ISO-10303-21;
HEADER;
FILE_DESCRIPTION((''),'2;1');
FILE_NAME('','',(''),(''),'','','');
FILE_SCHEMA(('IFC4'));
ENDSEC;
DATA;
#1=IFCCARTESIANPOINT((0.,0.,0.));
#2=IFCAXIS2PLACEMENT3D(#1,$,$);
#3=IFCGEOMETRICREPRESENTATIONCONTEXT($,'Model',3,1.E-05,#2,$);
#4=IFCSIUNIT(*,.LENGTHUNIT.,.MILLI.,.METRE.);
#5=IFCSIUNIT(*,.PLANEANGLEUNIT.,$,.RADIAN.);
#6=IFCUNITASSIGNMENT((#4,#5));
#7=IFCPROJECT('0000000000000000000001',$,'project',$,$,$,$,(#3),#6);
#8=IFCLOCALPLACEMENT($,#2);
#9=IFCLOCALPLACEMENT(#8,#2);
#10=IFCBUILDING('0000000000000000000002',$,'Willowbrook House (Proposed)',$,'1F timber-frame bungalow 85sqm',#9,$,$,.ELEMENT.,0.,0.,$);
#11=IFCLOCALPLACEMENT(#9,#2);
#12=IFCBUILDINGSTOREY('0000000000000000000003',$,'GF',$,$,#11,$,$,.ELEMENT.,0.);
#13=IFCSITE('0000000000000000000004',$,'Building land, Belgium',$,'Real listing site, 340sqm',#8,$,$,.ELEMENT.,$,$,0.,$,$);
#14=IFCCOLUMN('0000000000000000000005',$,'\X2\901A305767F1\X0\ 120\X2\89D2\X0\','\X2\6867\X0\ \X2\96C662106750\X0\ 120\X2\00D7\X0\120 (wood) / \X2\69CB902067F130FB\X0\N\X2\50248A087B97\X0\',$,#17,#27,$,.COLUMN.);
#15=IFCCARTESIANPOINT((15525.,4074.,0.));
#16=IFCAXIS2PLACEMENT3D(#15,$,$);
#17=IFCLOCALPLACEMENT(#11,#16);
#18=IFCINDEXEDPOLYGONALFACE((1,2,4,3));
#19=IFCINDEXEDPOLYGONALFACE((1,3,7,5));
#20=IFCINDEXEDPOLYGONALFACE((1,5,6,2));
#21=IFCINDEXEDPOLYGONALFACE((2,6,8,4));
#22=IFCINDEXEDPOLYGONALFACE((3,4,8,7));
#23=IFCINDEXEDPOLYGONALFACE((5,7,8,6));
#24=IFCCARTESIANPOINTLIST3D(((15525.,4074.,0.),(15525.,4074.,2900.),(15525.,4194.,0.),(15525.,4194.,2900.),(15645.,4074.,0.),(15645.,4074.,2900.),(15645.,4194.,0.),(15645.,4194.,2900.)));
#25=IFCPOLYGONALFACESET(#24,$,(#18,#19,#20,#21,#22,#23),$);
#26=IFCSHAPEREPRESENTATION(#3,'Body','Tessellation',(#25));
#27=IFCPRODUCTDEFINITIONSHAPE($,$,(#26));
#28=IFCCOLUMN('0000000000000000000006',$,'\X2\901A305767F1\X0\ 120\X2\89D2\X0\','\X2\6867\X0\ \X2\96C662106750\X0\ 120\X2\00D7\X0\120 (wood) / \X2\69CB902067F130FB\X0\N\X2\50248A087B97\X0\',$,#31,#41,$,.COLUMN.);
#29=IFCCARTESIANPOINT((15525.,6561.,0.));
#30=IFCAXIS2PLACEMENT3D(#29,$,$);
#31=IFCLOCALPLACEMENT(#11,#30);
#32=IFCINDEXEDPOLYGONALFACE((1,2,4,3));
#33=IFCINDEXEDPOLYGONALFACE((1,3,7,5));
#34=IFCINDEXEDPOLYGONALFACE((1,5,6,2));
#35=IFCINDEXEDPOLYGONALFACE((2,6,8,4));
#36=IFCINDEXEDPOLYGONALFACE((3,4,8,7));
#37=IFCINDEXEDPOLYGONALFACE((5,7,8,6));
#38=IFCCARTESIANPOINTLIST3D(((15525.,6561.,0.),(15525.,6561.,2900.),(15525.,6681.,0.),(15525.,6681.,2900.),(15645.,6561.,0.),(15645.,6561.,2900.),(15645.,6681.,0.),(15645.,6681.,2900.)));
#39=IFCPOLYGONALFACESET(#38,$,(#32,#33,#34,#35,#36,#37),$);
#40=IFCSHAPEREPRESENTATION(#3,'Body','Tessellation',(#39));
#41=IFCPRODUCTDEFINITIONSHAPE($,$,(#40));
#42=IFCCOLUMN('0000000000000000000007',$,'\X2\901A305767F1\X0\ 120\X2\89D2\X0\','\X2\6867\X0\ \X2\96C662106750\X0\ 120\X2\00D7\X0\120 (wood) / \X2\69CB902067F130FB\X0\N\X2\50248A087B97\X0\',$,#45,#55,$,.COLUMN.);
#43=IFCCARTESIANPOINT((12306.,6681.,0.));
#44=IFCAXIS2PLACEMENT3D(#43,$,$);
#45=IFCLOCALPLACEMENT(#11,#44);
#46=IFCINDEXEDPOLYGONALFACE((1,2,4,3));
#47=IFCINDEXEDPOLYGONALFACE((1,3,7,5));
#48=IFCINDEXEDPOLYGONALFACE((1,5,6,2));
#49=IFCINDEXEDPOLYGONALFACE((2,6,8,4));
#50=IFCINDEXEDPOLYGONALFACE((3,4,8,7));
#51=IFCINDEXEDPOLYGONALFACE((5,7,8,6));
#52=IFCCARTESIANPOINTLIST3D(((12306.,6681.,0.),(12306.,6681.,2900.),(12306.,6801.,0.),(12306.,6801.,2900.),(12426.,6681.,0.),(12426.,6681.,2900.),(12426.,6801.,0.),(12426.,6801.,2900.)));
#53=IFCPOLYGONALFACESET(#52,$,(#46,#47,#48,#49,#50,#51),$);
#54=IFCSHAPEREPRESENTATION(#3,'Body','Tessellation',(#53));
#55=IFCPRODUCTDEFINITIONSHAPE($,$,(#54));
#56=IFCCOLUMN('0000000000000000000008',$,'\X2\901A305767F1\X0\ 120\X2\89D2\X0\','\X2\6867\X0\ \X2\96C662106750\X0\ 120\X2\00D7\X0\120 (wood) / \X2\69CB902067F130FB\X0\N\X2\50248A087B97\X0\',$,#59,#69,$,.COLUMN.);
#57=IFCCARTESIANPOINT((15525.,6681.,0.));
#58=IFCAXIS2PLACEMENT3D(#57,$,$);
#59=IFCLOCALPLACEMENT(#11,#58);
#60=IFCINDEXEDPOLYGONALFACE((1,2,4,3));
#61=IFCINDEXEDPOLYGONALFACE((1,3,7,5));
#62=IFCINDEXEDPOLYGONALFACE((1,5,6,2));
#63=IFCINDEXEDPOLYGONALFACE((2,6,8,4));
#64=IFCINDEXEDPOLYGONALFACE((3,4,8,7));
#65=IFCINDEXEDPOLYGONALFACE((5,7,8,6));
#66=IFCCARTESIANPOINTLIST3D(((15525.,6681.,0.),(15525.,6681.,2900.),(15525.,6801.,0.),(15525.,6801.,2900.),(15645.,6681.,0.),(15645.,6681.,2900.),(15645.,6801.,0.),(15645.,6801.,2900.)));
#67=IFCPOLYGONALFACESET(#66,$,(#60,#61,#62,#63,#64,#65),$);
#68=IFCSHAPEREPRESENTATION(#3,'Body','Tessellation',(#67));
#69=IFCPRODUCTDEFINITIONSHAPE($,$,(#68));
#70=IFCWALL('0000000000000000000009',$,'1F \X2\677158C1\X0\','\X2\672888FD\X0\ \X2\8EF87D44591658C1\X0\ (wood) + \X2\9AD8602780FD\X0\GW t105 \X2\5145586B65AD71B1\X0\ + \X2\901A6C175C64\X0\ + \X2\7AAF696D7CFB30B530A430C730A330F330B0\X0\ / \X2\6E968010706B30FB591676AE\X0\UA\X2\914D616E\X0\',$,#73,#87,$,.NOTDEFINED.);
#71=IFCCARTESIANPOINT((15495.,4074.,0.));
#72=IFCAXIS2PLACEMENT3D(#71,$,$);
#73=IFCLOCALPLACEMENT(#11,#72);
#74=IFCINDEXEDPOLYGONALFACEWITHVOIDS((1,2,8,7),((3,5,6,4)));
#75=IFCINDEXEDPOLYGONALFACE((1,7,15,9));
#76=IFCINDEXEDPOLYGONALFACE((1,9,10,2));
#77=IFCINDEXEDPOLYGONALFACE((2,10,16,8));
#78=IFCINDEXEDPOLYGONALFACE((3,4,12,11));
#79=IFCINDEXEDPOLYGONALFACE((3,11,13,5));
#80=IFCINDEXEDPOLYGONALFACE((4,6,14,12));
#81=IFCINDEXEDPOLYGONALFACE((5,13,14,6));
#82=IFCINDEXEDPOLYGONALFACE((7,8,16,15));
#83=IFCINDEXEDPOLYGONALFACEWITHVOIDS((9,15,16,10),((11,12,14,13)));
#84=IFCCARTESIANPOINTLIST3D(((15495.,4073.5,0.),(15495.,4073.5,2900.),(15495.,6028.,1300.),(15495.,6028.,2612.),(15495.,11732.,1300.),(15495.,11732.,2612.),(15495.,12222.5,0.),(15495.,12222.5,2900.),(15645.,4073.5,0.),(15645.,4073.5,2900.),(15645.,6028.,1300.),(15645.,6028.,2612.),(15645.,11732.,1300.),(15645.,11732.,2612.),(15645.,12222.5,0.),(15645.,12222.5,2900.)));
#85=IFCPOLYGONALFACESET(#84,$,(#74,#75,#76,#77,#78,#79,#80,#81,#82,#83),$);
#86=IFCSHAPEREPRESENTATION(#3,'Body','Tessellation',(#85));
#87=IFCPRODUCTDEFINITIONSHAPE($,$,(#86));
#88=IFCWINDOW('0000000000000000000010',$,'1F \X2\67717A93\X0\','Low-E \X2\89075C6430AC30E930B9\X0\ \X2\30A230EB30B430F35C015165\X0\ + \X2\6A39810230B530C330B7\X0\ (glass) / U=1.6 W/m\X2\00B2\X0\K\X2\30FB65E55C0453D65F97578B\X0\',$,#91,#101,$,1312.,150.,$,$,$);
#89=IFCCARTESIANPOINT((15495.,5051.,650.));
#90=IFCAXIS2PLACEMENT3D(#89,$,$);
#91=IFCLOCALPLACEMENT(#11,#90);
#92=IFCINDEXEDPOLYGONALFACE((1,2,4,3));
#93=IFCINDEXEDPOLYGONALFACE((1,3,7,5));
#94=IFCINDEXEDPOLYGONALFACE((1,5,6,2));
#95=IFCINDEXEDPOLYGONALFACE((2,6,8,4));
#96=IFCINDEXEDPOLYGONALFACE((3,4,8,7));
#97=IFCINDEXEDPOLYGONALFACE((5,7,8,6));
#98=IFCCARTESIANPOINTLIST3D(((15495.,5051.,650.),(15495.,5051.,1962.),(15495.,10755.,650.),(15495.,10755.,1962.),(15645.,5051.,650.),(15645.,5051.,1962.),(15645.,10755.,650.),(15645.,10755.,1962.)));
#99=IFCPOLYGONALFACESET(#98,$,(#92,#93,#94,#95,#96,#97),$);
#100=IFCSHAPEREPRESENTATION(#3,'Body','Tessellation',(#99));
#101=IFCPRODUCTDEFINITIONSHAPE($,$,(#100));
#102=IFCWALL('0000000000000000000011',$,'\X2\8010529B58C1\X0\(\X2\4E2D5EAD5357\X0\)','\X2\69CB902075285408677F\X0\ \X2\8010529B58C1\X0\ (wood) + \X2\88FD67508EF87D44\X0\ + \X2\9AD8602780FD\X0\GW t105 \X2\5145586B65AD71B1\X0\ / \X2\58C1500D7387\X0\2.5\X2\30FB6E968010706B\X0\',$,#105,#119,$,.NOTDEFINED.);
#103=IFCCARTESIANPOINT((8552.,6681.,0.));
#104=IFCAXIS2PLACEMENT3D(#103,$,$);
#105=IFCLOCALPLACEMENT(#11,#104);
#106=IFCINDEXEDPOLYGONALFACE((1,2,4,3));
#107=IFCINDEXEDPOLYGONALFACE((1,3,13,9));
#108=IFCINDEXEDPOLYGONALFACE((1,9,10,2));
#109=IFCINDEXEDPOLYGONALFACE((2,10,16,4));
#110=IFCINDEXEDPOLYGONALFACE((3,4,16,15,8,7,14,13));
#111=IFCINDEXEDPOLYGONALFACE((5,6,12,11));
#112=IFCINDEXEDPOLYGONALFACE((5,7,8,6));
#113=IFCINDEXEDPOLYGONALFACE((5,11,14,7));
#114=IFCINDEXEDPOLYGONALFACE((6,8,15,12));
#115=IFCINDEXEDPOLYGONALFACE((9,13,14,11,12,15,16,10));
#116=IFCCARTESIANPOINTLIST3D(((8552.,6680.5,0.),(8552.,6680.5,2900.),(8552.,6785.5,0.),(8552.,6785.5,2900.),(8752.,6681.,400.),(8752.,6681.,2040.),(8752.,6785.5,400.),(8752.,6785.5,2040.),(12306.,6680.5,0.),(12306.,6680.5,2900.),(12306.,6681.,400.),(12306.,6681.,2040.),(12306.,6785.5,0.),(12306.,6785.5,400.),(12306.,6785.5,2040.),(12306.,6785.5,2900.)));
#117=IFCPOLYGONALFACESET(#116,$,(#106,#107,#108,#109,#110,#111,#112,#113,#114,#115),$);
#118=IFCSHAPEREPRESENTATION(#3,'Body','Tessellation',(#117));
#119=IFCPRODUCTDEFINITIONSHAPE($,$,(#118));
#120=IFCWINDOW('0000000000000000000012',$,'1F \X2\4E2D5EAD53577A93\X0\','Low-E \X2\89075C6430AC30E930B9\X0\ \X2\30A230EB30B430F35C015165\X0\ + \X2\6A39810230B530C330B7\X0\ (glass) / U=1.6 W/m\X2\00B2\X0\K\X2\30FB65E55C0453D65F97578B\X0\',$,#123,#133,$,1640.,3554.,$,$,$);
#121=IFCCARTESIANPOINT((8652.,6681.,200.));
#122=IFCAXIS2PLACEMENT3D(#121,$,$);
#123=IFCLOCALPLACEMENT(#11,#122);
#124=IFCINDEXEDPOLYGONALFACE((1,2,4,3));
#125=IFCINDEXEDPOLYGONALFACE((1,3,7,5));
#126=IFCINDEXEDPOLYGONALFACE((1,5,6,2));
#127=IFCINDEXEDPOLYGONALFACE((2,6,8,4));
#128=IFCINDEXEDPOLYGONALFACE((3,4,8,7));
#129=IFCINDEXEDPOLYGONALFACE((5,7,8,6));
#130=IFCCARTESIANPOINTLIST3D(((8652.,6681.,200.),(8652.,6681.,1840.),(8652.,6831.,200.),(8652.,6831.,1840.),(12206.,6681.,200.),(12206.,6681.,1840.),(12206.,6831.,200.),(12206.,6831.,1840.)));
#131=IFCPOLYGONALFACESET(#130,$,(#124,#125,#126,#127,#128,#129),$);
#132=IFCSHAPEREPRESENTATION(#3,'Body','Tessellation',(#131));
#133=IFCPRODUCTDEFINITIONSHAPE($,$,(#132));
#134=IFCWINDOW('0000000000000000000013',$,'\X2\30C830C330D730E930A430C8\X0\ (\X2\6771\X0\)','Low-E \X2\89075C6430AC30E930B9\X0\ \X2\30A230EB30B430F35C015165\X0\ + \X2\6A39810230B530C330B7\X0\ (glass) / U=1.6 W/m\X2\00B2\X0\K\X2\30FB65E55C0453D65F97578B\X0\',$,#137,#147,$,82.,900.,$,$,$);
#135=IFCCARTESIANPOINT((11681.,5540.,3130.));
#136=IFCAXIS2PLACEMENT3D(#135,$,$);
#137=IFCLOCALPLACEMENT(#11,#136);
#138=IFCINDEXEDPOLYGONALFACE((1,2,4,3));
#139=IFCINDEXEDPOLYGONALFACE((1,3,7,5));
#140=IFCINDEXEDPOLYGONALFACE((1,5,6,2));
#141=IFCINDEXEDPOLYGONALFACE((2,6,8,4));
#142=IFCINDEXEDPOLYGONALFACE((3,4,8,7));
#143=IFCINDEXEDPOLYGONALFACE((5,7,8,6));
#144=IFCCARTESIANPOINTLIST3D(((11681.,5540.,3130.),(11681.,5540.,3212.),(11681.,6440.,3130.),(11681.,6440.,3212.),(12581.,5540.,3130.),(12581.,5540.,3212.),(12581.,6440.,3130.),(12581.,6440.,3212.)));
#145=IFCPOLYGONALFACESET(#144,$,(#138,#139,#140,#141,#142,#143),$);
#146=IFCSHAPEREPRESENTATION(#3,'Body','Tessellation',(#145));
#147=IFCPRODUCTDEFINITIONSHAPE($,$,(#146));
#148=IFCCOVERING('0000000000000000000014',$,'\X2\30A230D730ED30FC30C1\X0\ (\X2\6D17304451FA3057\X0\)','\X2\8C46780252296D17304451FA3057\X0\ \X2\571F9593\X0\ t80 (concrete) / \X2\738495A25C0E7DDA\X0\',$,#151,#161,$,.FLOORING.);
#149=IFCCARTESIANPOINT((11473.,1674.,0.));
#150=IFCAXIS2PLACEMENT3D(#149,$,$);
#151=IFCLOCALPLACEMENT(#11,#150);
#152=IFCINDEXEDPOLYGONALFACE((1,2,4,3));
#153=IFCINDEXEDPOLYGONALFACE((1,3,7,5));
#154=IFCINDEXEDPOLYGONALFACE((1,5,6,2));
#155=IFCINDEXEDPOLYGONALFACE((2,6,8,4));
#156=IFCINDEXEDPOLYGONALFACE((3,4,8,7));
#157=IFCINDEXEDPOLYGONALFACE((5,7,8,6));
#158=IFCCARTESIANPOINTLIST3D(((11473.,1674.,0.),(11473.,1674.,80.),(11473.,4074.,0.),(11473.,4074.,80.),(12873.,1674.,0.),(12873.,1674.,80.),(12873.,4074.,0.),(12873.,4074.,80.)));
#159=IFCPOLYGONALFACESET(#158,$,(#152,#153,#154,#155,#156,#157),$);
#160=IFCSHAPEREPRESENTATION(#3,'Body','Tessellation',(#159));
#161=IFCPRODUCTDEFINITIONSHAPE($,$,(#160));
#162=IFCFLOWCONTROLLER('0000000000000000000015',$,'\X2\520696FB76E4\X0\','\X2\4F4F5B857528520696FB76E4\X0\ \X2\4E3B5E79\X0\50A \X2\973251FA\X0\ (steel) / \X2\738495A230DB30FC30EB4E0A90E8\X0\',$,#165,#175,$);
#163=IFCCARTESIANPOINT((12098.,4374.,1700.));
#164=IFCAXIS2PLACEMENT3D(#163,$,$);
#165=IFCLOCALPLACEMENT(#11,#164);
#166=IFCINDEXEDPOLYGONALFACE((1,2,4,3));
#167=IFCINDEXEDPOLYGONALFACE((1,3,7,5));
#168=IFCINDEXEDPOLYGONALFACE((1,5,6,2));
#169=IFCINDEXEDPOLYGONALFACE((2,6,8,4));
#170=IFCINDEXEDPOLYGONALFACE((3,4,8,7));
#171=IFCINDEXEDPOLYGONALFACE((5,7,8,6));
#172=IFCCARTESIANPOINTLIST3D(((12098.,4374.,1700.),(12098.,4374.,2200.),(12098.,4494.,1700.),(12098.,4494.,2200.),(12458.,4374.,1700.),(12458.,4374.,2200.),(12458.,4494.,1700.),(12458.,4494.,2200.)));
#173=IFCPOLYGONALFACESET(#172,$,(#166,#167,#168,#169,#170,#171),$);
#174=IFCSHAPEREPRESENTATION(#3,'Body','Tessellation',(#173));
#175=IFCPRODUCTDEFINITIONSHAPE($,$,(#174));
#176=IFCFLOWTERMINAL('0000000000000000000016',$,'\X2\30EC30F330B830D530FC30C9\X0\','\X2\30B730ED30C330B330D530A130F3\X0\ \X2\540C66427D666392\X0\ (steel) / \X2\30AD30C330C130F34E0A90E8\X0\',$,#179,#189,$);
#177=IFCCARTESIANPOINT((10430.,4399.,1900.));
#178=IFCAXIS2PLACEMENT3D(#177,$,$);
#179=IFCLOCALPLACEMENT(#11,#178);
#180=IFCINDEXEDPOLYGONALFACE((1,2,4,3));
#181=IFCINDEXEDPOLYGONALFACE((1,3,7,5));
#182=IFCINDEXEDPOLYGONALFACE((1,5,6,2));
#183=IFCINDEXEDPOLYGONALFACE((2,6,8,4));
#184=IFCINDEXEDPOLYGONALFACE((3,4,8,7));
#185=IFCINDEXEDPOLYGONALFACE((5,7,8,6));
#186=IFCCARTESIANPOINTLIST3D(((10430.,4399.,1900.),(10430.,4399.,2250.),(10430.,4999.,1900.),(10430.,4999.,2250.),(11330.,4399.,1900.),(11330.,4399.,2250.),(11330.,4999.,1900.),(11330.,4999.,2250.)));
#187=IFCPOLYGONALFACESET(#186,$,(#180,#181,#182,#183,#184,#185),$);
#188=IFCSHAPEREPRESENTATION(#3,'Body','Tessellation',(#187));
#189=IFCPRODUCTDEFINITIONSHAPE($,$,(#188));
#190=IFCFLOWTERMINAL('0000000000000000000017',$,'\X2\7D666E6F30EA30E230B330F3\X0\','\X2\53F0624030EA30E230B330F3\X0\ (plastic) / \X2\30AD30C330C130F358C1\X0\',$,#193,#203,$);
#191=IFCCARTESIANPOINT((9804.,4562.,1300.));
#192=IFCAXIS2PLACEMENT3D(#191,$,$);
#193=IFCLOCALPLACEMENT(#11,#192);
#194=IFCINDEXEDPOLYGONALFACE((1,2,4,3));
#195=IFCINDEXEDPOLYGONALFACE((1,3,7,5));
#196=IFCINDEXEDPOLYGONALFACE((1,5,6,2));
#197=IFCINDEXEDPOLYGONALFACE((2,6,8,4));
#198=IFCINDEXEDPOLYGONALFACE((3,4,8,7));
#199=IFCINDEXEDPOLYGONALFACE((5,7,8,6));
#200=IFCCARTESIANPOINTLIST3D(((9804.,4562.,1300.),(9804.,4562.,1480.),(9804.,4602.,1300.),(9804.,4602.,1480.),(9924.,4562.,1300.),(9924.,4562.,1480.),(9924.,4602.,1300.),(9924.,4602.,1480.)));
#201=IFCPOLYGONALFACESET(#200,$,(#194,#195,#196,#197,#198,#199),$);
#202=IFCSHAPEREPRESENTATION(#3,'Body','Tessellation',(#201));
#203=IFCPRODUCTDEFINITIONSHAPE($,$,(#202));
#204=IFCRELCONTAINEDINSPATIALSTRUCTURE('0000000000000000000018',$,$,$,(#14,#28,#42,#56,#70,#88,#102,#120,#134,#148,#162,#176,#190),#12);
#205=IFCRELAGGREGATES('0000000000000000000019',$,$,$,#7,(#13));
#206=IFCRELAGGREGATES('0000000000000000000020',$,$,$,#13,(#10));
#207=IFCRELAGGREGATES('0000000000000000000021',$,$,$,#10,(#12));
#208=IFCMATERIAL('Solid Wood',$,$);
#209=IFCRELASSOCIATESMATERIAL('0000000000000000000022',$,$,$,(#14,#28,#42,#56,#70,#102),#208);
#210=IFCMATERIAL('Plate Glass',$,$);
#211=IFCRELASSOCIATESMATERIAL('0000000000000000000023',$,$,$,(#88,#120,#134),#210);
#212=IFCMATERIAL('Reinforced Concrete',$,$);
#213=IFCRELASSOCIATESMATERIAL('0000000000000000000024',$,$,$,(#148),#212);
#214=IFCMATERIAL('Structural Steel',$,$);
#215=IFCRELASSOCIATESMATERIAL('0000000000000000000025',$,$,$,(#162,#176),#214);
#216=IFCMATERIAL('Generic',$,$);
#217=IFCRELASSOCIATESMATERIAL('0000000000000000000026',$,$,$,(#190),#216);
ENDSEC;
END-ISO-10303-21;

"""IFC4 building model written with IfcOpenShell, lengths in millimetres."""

from ifc_helpers import new_model, si_unit, frame, frame_2d, origin, place, context, project, spatial, rectangle, extrude, material, element, fill, save


model = new_model("IFC4")

# Units and contexts
model_context = context("Model", 3, precision=1e-05, world=origin())
ifc_project = project(units=[si_unit("LENGTHUNIT", "METRE", prefix="MILLI"), si_unit("PLANEANGLEUNIT", "RADIAN")], contexts=[model_context])

# Site, building, storey
site_placement = place(None, origin())
site = spatial("IfcSite", under=ifc_project, at=site_placement, Name="Building land, Belgium", ObjectType="Real listing site, 340sqm", CompositionType="ELEMENT", RefElevation=0.0)
building_placement = place(site_placement, origin())
building = spatial("IfcBuilding", under=site, at=building_placement, Name="Willowbrook House (Proposed)", ObjectType="1F timber-frame bungalow 85sqm", CompositionType="ELEMENT", ElevationOfRefHeight=0.0, ElevationOfTerrain=0.0)
storey_placement = place(building_placement, origin())
storey = spatial("IfcBuildingStorey", under=building, at=storey_placement, Name="GF", CompositionType="ELEMENT", Elevation=0.0)

# Columns
ifc_material_1 = material(Name="Solid Wood")
column_1_placement = place(storey_placement, frame((15525.0, 4074.0, 0.0)))
element("IfcColumn", 1, at=column_1_placement, inside=storey, material=ifc_material_1, Name="通し柱 120角", Description="桧 集成材 120×120 (wood) / 構造柱・N値計算", PredefinedType="COLUMN", context=model_context, shape_type="SweptSolid", body=[
    extrude(rectangle(XDim=120.0, YDim=120.0, at=frame_2d((60.0, 60.0))), frame((15525.0, 4074.0, 0.0)), (0.0, 0.0, 1.0), 2900.0),
])
column_2_placement = place(storey_placement, frame((15525.0, 6561.0, 0.0)))
element("IfcColumn", 2, at=column_2_placement, inside=storey, material=ifc_material_1, Name="通し柱 120角", Description="桧 集成材 120×120 (wood) / 構造柱・N値計算", PredefinedType="COLUMN", context=model_context, shape_type="SweptSolid", body=[
    extrude(rectangle(XDim=120.0, YDim=120.0, at=frame_2d((60.0, 60.0))), frame((15525.0, 6561.0, 0.0)), (0.0, 0.0, 1.0), 2900.0),
])
column_3_placement = place(storey_placement, frame((12306.0, 6681.0, 0.0)))
element("IfcColumn", 3, at=column_3_placement, inside=storey, material=ifc_material_1, Name="通し柱 120角", Description="桧 集成材 120×120 (wood) / 構造柱・N値計算", PredefinedType="COLUMN", context=model_context, shape_type="SweptSolid", body=[
    extrude(rectangle(XDim=120.0, YDim=120.0, at=frame_2d((60.0, 60.0))), frame((12306.0, 6681.0, 0.0)), (0.0, 0.0, 1.0), 2900.0),
])
column_4_placement = place(storey_placement, frame((15525.0, 6681.0, 0.0)))
element("IfcColumn", 4, at=column_4_placement, inside=storey, material=ifc_material_1, Name="通し柱 120角", Description="桧 集成材 120×120 (wood) / 構造柱・N値計算", PredefinedType="COLUMN", context=model_context, shape_type="SweptSolid", body=[
    extrude(rectangle(XDim=120.0, YDim=120.0, at=frame_2d((60.0, 60.0))), frame((15525.0, 6681.0, 0.0)), (0.0, 0.0, 1.0), 2900.0),
])

# Walls, openings, windows
wall_1_placement = place(storey_placement, frame((15495.0, 4074.0, 0.0)))
wall_1 = element("IfcWall", 5, at=wall_1_placement, inside=storey, material=ifc_material_1, Name="1F 東壁", Description="木製 軸組外壁 (wood) + 高性能GW t105 充填断熱 + 通気層 + 窯業系サイディング / 準耐火・外皮UA配慮", PredefinedType="NOTDEFINED", context=model_context, shape_type="SweptSolid", body=[
    extrude(rectangle(XDim=150.0, YDim=8149.0, at=frame_2d((75.0, 4074.0))), frame((15495.0, 4074.0, 0.0)), (0.0, 0.0, 1.0), 2900.0),
])
opening_1_placement = place(storey_placement, frame((15495.0, 5051.0, 650.0)))
opening_1 = element("IfcOpeningElement", 6, at=opening_1_placement, cuts=wall_1, PredefinedType="NOTDEFINED", context=model_context, shape_type="SweptSolid", body=[
    extrude(rectangle(XDim=150.0, YDim=5704.0, at=frame_2d((75.0, 2852.0))), frame((15495.0, 5051.0, 650.0)), (0.0, 0.0, 1.0), 1312.0),
])
ifc_material_2 = material(Name="Plate Glass")
window_1_placement = place(storey_placement, frame((15495.0, 5051.0, 650.0)))
window_1 = element("IfcWindow", 7, at=window_1_placement, inside=storey, material=ifc_material_2, Name="1F 東窓", Description="Low-E 複層ガラス アルゴン封入 + 樹脂サッシ (glass) / U=1.6 W/m²K・日射取得型", OverallHeight=1312.0, OverallWidth=150.0, context=model_context, shape_type="SweptSolid", body=[
    extrude(rectangle(XDim=150.0, YDim=5704.0, at=frame_2d((75.0, 2852.0))), frame((15495.0, 5051.0, 650.0)), (0.0, 0.0, 1.0), 1312.0),
])
fill(opening_1, window_1)
wall_2_placement = place(storey_placement, frame((8552.0, 6681.0, 0.0)))
wall_2 = element("IfcWall", 8, at=wall_2_placement, inside=storey, material=ifc_material_1, Name="耐力壁(中庭南)", Description="構造用合板 耐力壁 (wood) + 製材軸組 + 高性能GW t105 充填断熱 / 壁倍率2.5・準耐火", PredefinedType="NOTDEFINED", context=model_context, shape_type="SweptSolid", body=[
    extrude(rectangle(XDim=3754.0, YDim=105.0, at=frame_2d((1877.0, 52.0))), frame((8552.0, 6681.0, 0.0)), (0.0, 0.0, 1.0), 2900.0),
])
opening_2_placement = place(storey_placement, frame((8652.0, 6681.0, 200.0)))
opening_2 = element("IfcOpeningElement", 9, at=opening_2_placement, cuts=wall_2, PredefinedType="NOTDEFINED", context=model_context, shape_type="SweptSolid", body=[
    extrude(rectangle(XDim=3554.0, YDim=150.0, at=frame_2d((1777.0, 75.0))), frame((8652.0, 6681.0, 200.0)), (0.0, 0.0, 1.0), 1640.0),
])
window_2_placement = place(storey_placement, frame((8652.0, 6681.0, 200.0)))
window_2 = element("IfcWindow", 10, at=window_2_placement, inside=storey, material=ifc_material_2, Name="1F 中庭南窓", Description="Low-E 複層ガラス アルゴン封入 + 樹脂サッシ (glass) / U=1.6 W/m²K・日射取得型", OverallHeight=1640.0, OverallWidth=3554.0, context=model_context, shape_type="SweptSolid", body=[
    extrude(rectangle(XDim=3554.0, YDim=150.0, at=frame_2d((1777.0, 75.0))), frame((8652.0, 6681.0, 200.0)), (0.0, 0.0, 1.0), 1640.0),
])
fill(opening_2, window_2)

# Window
window_3_placement = place(storey_placement, frame((11681.0, 5540.0, 3130.0)))
element("IfcWindow", 11, at=window_3_placement, inside=storey, material=ifc_material_2, Name="トップライト (東)", Description="Low-E 複層ガラス アルゴン封入 + 樹脂サッシ (glass) / U=1.6 W/m²K・日射取得型", OverallHeight=82.0, OverallWidth=900.0, context=model_context, shape_type="SweptSolid", body=[
    extrude(rectangle(XDim=900.0, YDim=900.0, at=frame_2d((450.0, 450.0))), frame((11681.0, 5540.0, 3130.0)), (0.0, 0.0, 1.0), 82.0),
])

# Shared definitions
ifc_material_3 = material(Name="Structural Steel")

# Covering
ifc_material_4 = material(Name="Reinforced Concrete")
covering_placement = place(storey_placement, frame((11473.0, 1674.0, 0.0)))
element("IfcCovering", 12, at=covering_placement, inside=storey, material=ifc_material_4, Name="アプローチ (洗い出し)", Description="豆砂利洗い出し 土間 t80 (concrete) / 玄関導線", PredefinedType="FLOORING", context=model_context, shape_type="SweptSolid", body=[
    extrude(rectangle(XDim=1400.0, YDim=2400.0, at=frame_2d((700.0, 1200.0))), frame((11473.0, 1674.0, 0.0)), (0.0, 0.0, 1.0), 80.0),
])

# Flow controller
flow_controller_placement = place(storey_placement, frame((12098.0, 4374.0, 1700.0)))
element("IfcFlowController", 13, at=flow_controller_placement, inside=storey, material=ifc_material_3, Name="分電盤", Description="住宅用分電盤 主幹50A 露出 (steel) / 玄関ホール上部", context=model_context, shape_type="SweptSolid", body=[
    extrude(rectangle(XDim=360.0, YDim=120.0, at=frame_2d((180.0, 60.0))), frame((12098.0, 4374.0, 1700.0)), (0.0, 0.0, 1.0), 500.0),
])

# Flow terminals
flow_terminal_1_placement = place(storey_placement, frame((10430.0, 4399.0, 1900.0)))
element("IfcFlowTerminal", 14, at=flow_terminal_1_placement, inside=storey, material=ifc_material_3, Name="レンジフード", Description="シロッコファン 同時給排 (steel) / キッチン上部", context=model_context, shape_type="SweptSolid", body=[
    extrude(rectangle(XDim=900.0, YDim=600.0, at=frame_2d((450.0, 300.0))), frame((10430.0, 4399.0, 1900.0)), (0.0, 0.0, 1.0), 350.0),
])
ifc_material_5 = material(Name="Generic")
flow_terminal_2_placement = place(storey_placement, frame((9804.0, 4562.0, 1300.0)))
element("IfcFlowTerminal", 15, at=flow_terminal_2_placement, inside=storey, material=ifc_material_5, Name="給湯リモコン", Description="台所リモコン (plastic) / キッチン壁", context=model_context, shape_type="SweptSolid", body=[
    extrude(rectangle(XDim=120.0, YDim=40.0, at=frame_2d((60.0, 20.0))), frame((9804.0, 4562.0, 1300.0)), (0.0, 0.0, 1.0), 180.0),
])

save(model, "model.ifc")
